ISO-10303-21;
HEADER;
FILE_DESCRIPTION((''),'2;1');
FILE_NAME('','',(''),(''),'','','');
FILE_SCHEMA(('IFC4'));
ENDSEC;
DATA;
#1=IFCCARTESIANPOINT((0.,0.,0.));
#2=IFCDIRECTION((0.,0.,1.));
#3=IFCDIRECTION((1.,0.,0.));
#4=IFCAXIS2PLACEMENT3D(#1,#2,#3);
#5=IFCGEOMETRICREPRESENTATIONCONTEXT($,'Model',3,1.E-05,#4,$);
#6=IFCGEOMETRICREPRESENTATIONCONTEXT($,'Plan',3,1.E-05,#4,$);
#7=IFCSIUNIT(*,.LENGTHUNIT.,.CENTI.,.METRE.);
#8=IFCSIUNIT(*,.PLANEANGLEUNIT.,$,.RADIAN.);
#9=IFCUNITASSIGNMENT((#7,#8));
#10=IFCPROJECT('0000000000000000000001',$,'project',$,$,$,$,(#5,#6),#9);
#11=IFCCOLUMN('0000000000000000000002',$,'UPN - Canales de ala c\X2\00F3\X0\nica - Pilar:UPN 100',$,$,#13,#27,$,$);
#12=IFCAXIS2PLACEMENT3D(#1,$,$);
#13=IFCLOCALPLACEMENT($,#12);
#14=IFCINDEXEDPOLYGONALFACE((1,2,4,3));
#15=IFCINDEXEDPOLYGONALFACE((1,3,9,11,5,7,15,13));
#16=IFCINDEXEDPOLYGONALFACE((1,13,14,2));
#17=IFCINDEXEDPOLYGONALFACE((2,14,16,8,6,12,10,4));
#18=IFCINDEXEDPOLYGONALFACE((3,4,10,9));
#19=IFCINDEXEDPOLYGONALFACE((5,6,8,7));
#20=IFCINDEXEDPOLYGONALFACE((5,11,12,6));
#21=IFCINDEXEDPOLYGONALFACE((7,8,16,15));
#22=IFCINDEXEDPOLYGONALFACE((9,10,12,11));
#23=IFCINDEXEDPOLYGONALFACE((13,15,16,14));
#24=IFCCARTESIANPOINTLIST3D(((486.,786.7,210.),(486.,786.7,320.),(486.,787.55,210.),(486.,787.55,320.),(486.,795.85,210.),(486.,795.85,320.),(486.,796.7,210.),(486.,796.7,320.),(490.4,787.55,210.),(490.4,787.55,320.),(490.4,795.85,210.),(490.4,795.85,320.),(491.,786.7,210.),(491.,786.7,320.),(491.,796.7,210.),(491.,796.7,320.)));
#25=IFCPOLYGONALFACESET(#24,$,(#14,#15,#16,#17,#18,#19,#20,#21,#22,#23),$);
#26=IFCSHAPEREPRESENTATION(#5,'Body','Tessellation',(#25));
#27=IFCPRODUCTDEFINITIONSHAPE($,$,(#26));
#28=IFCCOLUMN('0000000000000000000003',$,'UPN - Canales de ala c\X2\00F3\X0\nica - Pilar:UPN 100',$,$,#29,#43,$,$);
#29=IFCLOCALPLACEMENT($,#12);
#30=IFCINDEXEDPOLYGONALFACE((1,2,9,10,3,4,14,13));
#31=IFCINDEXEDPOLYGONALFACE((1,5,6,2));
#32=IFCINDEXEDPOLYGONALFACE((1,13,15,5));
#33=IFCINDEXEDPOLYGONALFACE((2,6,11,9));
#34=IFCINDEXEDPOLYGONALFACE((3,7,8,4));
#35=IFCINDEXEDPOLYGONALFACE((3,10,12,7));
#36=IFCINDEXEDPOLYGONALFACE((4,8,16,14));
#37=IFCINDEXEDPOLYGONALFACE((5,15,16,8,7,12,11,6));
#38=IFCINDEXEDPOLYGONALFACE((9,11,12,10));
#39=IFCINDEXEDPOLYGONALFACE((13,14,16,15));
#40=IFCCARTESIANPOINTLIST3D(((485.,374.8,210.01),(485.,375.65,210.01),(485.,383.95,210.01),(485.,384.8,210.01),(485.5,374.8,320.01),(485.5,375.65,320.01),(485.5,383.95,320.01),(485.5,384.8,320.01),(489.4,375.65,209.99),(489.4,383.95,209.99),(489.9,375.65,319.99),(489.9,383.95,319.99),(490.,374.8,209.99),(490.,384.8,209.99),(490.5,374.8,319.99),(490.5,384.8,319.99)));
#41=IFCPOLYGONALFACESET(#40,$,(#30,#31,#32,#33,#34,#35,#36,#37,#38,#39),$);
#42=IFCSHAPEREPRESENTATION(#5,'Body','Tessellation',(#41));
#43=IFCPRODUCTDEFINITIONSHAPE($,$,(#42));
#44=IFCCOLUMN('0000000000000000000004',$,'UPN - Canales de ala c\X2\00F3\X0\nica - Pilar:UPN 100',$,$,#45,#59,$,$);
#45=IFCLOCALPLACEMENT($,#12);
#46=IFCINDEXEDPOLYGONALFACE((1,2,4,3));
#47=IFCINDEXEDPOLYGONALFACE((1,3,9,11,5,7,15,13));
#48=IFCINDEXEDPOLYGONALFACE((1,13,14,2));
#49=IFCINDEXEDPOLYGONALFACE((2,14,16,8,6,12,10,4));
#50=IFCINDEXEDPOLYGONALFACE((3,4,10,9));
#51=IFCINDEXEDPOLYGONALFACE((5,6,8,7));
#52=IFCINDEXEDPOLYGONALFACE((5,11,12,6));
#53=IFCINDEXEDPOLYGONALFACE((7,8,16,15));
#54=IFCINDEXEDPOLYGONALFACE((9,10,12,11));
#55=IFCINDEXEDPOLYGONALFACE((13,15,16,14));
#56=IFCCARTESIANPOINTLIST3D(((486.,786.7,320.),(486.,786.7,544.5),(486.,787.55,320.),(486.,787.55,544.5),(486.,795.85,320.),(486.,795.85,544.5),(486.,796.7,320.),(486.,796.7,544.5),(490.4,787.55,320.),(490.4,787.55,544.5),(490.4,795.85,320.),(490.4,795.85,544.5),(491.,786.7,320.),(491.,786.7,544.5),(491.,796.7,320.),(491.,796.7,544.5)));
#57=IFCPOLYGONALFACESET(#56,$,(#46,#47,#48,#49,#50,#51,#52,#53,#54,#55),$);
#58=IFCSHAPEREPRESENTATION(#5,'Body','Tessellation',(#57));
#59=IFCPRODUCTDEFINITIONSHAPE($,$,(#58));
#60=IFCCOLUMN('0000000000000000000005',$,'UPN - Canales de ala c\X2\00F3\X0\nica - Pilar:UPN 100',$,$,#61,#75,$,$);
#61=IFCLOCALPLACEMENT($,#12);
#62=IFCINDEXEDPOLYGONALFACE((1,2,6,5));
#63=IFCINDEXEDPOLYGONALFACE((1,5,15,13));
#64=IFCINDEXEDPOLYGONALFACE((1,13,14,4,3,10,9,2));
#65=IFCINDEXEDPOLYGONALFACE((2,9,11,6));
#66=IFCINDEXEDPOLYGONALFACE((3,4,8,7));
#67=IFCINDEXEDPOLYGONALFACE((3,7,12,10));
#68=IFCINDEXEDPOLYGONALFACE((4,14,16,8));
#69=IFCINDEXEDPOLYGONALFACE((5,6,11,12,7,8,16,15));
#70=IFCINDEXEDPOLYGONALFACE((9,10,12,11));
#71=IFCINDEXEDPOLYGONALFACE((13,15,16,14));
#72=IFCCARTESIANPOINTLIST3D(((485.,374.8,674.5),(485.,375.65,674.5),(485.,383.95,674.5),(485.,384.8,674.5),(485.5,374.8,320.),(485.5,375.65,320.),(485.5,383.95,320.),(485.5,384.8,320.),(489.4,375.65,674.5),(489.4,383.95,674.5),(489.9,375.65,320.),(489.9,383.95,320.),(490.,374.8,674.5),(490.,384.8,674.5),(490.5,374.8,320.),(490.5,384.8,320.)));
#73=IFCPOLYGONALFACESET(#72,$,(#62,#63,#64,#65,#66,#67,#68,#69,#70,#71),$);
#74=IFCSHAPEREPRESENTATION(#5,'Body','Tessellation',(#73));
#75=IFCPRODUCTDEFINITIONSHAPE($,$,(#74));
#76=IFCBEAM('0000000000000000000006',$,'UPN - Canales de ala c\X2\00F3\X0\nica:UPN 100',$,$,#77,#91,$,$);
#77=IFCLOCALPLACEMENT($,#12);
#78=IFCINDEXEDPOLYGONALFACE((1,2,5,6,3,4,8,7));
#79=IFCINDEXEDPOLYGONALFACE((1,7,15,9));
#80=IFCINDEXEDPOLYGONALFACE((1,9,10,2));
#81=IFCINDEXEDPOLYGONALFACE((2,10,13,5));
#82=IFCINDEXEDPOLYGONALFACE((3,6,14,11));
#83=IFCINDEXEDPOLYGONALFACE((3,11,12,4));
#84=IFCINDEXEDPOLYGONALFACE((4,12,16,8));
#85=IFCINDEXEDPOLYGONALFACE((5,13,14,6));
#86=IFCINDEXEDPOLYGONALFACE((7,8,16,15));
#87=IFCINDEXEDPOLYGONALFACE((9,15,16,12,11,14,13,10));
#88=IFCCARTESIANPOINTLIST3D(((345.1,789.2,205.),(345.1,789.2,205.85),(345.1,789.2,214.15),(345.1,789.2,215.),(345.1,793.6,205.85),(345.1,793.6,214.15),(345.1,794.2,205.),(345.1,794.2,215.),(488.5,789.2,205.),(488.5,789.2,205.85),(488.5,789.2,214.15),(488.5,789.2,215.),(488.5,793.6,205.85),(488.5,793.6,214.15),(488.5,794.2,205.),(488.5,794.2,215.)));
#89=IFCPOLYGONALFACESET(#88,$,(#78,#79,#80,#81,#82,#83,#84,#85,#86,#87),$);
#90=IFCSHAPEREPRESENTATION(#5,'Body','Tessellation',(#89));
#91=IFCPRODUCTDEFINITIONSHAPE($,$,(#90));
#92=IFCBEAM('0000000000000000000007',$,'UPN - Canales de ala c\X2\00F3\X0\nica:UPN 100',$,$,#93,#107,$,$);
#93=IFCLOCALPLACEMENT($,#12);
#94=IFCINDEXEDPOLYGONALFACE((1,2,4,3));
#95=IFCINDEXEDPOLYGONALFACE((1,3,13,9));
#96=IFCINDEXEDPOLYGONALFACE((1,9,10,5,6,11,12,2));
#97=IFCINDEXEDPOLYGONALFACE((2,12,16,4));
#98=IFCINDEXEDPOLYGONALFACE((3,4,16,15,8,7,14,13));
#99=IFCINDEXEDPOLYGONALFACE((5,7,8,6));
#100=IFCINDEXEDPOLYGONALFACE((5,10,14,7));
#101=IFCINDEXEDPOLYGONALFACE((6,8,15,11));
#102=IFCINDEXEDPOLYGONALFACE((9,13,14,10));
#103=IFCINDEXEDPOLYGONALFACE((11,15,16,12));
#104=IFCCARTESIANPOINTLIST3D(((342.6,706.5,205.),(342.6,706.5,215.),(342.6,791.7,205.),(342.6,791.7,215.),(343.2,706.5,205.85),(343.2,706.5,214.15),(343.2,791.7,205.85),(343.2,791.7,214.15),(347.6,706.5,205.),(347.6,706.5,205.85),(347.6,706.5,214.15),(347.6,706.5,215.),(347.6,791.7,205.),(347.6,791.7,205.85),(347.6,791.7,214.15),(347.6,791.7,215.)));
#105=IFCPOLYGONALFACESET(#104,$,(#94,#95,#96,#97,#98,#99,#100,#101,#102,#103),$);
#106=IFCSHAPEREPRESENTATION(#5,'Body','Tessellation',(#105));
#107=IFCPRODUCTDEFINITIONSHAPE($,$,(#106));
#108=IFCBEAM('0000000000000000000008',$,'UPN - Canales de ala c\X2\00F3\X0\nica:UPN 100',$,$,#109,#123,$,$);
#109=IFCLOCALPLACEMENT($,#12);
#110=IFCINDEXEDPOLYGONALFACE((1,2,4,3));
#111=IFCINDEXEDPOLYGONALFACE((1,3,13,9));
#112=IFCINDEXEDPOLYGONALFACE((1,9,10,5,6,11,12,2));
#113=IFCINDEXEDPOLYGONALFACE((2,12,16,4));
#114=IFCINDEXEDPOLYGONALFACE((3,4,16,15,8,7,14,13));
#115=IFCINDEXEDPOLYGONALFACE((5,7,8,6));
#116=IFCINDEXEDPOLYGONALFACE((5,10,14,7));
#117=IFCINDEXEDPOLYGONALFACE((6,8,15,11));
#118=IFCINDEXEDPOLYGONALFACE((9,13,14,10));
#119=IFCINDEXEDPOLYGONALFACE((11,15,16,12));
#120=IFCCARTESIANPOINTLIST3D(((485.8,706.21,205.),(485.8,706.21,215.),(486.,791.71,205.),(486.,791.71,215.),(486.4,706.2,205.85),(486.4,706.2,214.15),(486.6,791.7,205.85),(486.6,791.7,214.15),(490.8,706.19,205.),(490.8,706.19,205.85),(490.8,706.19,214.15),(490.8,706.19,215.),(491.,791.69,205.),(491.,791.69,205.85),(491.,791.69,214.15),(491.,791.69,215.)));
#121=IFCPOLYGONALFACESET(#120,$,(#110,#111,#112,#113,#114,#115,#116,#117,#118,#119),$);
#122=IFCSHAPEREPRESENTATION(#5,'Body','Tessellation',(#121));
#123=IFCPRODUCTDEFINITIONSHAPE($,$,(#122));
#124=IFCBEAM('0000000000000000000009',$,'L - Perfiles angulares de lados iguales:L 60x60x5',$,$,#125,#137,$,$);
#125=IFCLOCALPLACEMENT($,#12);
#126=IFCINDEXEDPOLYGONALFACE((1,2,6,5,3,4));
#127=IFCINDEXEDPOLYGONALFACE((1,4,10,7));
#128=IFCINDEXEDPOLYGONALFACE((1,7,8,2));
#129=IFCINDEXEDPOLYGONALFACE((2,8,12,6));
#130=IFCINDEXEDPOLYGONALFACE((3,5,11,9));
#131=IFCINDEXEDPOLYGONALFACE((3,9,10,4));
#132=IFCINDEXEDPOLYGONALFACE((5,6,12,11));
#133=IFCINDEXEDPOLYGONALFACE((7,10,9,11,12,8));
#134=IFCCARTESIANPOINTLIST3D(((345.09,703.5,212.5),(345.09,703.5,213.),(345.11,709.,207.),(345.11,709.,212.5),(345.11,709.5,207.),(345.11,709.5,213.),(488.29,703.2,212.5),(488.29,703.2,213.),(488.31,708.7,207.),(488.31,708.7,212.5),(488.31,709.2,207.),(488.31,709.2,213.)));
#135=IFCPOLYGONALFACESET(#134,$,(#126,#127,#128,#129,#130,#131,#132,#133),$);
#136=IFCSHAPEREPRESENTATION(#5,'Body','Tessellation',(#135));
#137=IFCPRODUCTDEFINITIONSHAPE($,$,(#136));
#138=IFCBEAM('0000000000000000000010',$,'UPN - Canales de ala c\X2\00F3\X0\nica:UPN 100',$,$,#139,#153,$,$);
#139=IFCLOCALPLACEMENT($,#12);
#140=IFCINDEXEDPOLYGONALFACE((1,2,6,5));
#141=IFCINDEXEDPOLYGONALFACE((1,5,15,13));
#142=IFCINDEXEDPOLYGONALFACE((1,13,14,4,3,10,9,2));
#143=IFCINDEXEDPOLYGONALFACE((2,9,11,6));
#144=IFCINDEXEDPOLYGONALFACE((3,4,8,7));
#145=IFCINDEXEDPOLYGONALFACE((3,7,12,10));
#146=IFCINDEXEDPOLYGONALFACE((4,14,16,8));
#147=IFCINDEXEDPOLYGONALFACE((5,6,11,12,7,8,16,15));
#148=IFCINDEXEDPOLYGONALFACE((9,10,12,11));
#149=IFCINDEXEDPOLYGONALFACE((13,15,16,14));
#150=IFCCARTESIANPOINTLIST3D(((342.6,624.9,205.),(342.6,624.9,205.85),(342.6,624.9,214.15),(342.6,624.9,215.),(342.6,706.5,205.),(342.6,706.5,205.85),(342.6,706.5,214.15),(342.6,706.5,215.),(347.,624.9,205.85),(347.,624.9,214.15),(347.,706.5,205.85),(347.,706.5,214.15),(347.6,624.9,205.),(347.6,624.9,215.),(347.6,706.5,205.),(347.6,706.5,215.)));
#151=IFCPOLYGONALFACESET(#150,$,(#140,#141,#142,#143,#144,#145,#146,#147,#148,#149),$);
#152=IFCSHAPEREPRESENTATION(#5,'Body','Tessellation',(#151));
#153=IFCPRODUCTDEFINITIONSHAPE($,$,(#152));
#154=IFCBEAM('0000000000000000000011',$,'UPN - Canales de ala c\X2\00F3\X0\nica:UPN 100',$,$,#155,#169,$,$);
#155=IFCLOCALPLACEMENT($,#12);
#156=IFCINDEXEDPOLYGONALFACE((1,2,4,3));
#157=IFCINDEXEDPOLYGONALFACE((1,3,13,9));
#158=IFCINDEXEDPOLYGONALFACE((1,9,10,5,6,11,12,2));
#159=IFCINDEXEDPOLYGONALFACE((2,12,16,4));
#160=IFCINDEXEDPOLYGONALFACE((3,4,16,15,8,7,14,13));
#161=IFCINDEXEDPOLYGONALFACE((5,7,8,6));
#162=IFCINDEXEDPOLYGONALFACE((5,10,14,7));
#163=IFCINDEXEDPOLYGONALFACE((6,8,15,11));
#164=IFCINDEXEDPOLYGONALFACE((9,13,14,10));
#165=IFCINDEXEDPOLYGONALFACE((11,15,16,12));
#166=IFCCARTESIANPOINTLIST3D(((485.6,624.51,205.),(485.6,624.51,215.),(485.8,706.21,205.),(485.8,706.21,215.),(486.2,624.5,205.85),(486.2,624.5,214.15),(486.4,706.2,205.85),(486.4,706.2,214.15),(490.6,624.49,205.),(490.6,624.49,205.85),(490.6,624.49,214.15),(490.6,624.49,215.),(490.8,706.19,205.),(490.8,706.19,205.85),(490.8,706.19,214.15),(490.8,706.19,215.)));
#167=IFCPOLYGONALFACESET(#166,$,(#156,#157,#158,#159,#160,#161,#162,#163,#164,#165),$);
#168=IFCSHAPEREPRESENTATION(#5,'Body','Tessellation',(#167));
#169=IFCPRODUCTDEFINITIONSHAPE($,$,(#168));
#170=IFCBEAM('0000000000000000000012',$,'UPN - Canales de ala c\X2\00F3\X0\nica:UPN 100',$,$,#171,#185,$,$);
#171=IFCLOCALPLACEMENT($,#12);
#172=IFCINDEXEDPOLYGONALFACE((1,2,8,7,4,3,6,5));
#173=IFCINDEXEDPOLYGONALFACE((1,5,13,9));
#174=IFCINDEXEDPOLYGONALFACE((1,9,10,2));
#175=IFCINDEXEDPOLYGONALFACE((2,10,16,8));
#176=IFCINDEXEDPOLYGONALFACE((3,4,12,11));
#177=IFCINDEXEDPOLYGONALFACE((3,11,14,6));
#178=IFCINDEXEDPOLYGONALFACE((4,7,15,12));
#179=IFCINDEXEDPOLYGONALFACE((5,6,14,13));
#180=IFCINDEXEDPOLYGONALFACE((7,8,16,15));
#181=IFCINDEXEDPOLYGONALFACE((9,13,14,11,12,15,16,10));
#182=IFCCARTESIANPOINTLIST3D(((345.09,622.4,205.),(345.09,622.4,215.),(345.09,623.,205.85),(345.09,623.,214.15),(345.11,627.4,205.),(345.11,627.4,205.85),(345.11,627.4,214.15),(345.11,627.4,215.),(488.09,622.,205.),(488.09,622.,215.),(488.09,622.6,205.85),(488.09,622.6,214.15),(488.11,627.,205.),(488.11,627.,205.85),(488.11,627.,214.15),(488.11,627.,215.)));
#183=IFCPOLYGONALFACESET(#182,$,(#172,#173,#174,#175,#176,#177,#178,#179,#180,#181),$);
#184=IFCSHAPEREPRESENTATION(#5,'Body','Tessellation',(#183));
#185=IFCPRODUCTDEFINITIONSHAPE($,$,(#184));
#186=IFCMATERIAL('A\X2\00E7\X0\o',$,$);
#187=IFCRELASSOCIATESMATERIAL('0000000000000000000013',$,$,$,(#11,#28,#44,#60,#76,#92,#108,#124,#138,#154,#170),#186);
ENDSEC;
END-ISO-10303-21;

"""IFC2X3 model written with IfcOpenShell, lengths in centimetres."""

from ifc_helpers import new_model, si_unit, frame, frame_2d, origin_with_axes, origin_2d_with_axis, place, context, project, polyline, u_section, outline, extrude, material, element, save


model = new_model("IFC2X3")

# Units and contexts
model_context = context("Model", 3, precision=1e-05, world=origin_with_axes())
plan_context = context("Plan", 3, precision=1e-05, world=origin_with_axes())
ifc_project = project(units=[si_unit("LENGTHUNIT", "METRE", prefix="CENTI"), si_unit("PLANEANGLEUNIT", "RADIAN")], contexts=[model_context, plan_context])

# Columns
ifc_material = material(Name="Aço")
column_1_placement = place(None, frame((488.5, 791.7, 210.0), z_axis=(0.0, 0.0, 1.0), x_axis=(-1.0, 0.0, 0.0)))
element("IfcColumn", 1, at=column_1_placement, material=ifc_material, Name="UPN - Canales de ala cónica - Pilar:UPN 100", context=model_context, shape_type="SweptSolid", body=[
    extrude(u_section(Depth=10.0, FlangeWidth=5.0, WebThickness=0.6, FlangeThickness=0.85, FilletRadius=0.0, EdgeRadius=0.0, FlangeSlope=0.0, CentreOfGravityInX=0.0, at=origin_2d_with_axis()), origin_with_axes(), (0.0, 0.0, 1.0), 110.0),
])
column_2_placement = place(None, frame((487.5, 379.8, 210.0), z_axis=(0.004545, 0.0, 0.99999), x_axis=(-0.99999, 0.0, 0.004545)))
element("IfcColumn", 2, at=column_2_placement, material=ifc_material, Name="UPN - Canales de ala cónica - Pilar:UPN 100", context=model_context, shape_type="SweptSolid", body=[
    extrude(u_section(Depth=10.0, FlangeWidth=5.0, WebThickness=0.6, FlangeThickness=0.85, FilletRadius=0.0, EdgeRadius=0.0, FlangeSlope=0.0, CentreOfGravityInX=0.0, at=origin_2d_with_axis()), origin_with_axes(), (0.0, 0.0, 1.0), 110.0),
])
column_3_placement = place(None, frame((488.5, 791.7, 320.0), z_axis=(0.0, 0.0, 1.0), x_axis=(-1.0, 0.0, 0.0)))
element("IfcColumn", 3, at=column_3_placement, material=ifc_material, Name="UPN - Canales de ala cónica - Pilar:UPN 100", context=model_context, shape_type="SweptSolid", body=[
    extrude(u_section(Depth=10.0, FlangeWidth=5.0, WebThickness=0.6, FlangeThickness=0.85, FilletRadius=0.0, EdgeRadius=0.0, FlangeSlope=0.0, CentreOfGravityInX=0.0, at=origin_2d_with_axis()), origin_with_axes(), (0.0, 0.0, 1.0), 224.5),
])
column_4_placement = place(None, frame((488.0, 379.8, 320.0), z_axis=(-0.00141, 0.0, 0.999999), x_axis=(-0.999999, 0.0, -0.00141)))
element("IfcColumn", 4, at=column_4_placement, material=ifc_material, Name="UPN - Canales de ala cónica - Pilar:UPN 100", context=model_context, shape_type="SweptSolid", body=[
    extrude(u_section(Depth=10.0, FlangeWidth=5.0, WebThickness=0.6, FlangeThickness=0.85, FilletRadius=0.0, EdgeRadius=0.0, FlangeSlope=0.0, CentreOfGravityInX=0.0, at=origin_2d_with_axis()), origin_with_axes(), (0.0, 0.0, 1.0), 354.5),
])

# Beams
beam_1_placement = place(None, frame((488.5, 791.7, 210.0), z_axis=(-1.0, 0.0, 0.0), x_axis=(0.0, -1.0, 0.0)))
element("IfcBeam", 5, at=beam_1_placement, material=ifc_material, Name="UPN - Canales de ala cónica:UPN 100", context=model_context, shape_type="SweptSolid", body=[
    extrude(u_section(Depth=10.0, FlangeWidth=5.0, WebThickness=0.6, FlangeThickness=0.85, FilletRadius=0.0, EdgeRadius=0.0, FlangeSlope=0.0, CentreOfGravityInX=0.0, at=origin_2d_with_axis()), origin_with_axes(), (0.0, 0.0, 1.0), 143.4),
])
beam_2_placement = place(None, frame((345.1, 706.5, 210.0), z_axis=(0.0, 1.0, 0.0), x_axis=(1.0, 0.0, 0.0)))
element("IfcBeam", 6, at=beam_2_placement, material=ifc_material, Name="UPN - Canales de ala cónica:UPN 100", context=model_context, shape_type="SweptSolid", body=[
    extrude(u_section(Depth=10.0, FlangeWidth=5.0, WebThickness=0.6, FlangeThickness=0.85, FilletRadius=0.0, EdgeRadius=0.0, FlangeSlope=0.0, CentreOfGravityInX=0.0, at=origin_2d_with_axis()), origin_with_axes(), (0.0, 0.0, 1.0), 85.2),
])
beam_3_placement = place(None, frame((488.3, 706.2, 210.0), z_axis=(0.002339, 0.999997, 0.0), x_axis=(0.999997, -0.002339, 0.0)))
element("IfcBeam", 7, at=beam_3_placement, material=ifc_material, Name="UPN - Canales de ala cónica:UPN 100", context=model_context, shape_type="SweptSolid", body=[
    extrude(u_section(Depth=10.0, FlangeWidth=5.0, WebThickness=0.6, FlangeThickness=0.85, FilletRadius=0.0, EdgeRadius=0.0, FlangeSlope=0.0, CentreOfGravityInX=0.0, at=frame_2d((0.0, 0.0), x_axis=(1.0, 0.0))), origin_with_axes(), (0.0, 0.0, 1.0), 85.5),
])
beam_4_placement = place(None, frame((488.3, 706.2, 210.0), z_axis=(-0.999998, 0.002095, 0.0), x_axis=(0.0, 0.0, 1.0)))
element("IfcBeam", 8, at=beam_4_placement, material=ifc_material, Name="L - Perfiles angulares de lados iguales:L 60x60x5", context=model_context, shape_type="SweptSolid", body=[
    extrude(outline(polyline([(3.0, -3.0), (3.0, 3.0), (-3.0, 3.0), (-3.0, 2.5), (2.5, 2.5), (2.5, -3.0), (3.0, -3.0)])), origin_with_axes(), (0.0, 0.0, 1.0), 143.2),
])
beam_5_placement = place(None, frame((345.1, 624.9, 210.0), z_axis=(0.0, 1.0, 0.0), x_axis=(-1.0, 0.0, 0.0)))
element("IfcBeam", 9, at=beam_5_placement, material=ifc_material, Name="UPN - Canales de ala cónica:UPN 100", context=model_context, shape_type="SweptSolid", body=[
    extrude(u_section(Depth=10.0, FlangeWidth=5.0, WebThickness=0.6, FlangeThickness=0.85, FilletRadius=0.0, EdgeRadius=0.0, FlangeSlope=0.0, CentreOfGravityInX=0.0, at=origin_2d_with_axis()), origin_with_axes(), (0.0, 0.0, 1.0), 81.6),
])
beam_6_placement = place(None, frame((488.1, 624.5, 210.0), z_axis=(0.002448, 0.999997, 0.0), x_axis=(0.999997, -0.002448, 0.0)))
element("IfcBeam", 10, at=beam_6_placement, material=ifc_material, Name="UPN - Canales de ala cónica:UPN 100", context=model_context, shape_type="SweptSolid", body=[
    extrude(u_section(Depth=10.0, FlangeWidth=5.0, WebThickness=0.6, FlangeThickness=0.85, FilletRadius=0.0, EdgeRadius=0.0, FlangeSlope=0.0, CentreOfGravityInX=0.0, at=frame_2d((0.0, 0.0), x_axis=(1.0, 0.0))), origin_with_axes(), (0.0, 0.0, 1.0), 81.7),
])
beam_7_placement = place(None, frame((488.1, 624.5, 210.0), z_axis=(-0.999996, 0.002797, 0.0), x_axis=(0.002797, 0.999996, 0.0)))
element("IfcBeam", 11, at=beam_7_placement, material=ifc_material, Name="UPN - Canales de ala cónica:UPN 100", context=model_context, shape_type="SweptSolid", body=[
    extrude(u_section(Depth=10.0, FlangeWidth=5.0, WebThickness=0.6, FlangeThickness=0.85, FilletRadius=0.0, EdgeRadius=0.0, FlangeSlope=0.0, CentreOfGravityInX=0.0, at=frame_2d((0.0, 0.0), x_axis=(1.0, 0.0))), origin_with_axes(), (0.0, 0.0, 1.0), 143.0),
])

save(model, "model.ifc")
